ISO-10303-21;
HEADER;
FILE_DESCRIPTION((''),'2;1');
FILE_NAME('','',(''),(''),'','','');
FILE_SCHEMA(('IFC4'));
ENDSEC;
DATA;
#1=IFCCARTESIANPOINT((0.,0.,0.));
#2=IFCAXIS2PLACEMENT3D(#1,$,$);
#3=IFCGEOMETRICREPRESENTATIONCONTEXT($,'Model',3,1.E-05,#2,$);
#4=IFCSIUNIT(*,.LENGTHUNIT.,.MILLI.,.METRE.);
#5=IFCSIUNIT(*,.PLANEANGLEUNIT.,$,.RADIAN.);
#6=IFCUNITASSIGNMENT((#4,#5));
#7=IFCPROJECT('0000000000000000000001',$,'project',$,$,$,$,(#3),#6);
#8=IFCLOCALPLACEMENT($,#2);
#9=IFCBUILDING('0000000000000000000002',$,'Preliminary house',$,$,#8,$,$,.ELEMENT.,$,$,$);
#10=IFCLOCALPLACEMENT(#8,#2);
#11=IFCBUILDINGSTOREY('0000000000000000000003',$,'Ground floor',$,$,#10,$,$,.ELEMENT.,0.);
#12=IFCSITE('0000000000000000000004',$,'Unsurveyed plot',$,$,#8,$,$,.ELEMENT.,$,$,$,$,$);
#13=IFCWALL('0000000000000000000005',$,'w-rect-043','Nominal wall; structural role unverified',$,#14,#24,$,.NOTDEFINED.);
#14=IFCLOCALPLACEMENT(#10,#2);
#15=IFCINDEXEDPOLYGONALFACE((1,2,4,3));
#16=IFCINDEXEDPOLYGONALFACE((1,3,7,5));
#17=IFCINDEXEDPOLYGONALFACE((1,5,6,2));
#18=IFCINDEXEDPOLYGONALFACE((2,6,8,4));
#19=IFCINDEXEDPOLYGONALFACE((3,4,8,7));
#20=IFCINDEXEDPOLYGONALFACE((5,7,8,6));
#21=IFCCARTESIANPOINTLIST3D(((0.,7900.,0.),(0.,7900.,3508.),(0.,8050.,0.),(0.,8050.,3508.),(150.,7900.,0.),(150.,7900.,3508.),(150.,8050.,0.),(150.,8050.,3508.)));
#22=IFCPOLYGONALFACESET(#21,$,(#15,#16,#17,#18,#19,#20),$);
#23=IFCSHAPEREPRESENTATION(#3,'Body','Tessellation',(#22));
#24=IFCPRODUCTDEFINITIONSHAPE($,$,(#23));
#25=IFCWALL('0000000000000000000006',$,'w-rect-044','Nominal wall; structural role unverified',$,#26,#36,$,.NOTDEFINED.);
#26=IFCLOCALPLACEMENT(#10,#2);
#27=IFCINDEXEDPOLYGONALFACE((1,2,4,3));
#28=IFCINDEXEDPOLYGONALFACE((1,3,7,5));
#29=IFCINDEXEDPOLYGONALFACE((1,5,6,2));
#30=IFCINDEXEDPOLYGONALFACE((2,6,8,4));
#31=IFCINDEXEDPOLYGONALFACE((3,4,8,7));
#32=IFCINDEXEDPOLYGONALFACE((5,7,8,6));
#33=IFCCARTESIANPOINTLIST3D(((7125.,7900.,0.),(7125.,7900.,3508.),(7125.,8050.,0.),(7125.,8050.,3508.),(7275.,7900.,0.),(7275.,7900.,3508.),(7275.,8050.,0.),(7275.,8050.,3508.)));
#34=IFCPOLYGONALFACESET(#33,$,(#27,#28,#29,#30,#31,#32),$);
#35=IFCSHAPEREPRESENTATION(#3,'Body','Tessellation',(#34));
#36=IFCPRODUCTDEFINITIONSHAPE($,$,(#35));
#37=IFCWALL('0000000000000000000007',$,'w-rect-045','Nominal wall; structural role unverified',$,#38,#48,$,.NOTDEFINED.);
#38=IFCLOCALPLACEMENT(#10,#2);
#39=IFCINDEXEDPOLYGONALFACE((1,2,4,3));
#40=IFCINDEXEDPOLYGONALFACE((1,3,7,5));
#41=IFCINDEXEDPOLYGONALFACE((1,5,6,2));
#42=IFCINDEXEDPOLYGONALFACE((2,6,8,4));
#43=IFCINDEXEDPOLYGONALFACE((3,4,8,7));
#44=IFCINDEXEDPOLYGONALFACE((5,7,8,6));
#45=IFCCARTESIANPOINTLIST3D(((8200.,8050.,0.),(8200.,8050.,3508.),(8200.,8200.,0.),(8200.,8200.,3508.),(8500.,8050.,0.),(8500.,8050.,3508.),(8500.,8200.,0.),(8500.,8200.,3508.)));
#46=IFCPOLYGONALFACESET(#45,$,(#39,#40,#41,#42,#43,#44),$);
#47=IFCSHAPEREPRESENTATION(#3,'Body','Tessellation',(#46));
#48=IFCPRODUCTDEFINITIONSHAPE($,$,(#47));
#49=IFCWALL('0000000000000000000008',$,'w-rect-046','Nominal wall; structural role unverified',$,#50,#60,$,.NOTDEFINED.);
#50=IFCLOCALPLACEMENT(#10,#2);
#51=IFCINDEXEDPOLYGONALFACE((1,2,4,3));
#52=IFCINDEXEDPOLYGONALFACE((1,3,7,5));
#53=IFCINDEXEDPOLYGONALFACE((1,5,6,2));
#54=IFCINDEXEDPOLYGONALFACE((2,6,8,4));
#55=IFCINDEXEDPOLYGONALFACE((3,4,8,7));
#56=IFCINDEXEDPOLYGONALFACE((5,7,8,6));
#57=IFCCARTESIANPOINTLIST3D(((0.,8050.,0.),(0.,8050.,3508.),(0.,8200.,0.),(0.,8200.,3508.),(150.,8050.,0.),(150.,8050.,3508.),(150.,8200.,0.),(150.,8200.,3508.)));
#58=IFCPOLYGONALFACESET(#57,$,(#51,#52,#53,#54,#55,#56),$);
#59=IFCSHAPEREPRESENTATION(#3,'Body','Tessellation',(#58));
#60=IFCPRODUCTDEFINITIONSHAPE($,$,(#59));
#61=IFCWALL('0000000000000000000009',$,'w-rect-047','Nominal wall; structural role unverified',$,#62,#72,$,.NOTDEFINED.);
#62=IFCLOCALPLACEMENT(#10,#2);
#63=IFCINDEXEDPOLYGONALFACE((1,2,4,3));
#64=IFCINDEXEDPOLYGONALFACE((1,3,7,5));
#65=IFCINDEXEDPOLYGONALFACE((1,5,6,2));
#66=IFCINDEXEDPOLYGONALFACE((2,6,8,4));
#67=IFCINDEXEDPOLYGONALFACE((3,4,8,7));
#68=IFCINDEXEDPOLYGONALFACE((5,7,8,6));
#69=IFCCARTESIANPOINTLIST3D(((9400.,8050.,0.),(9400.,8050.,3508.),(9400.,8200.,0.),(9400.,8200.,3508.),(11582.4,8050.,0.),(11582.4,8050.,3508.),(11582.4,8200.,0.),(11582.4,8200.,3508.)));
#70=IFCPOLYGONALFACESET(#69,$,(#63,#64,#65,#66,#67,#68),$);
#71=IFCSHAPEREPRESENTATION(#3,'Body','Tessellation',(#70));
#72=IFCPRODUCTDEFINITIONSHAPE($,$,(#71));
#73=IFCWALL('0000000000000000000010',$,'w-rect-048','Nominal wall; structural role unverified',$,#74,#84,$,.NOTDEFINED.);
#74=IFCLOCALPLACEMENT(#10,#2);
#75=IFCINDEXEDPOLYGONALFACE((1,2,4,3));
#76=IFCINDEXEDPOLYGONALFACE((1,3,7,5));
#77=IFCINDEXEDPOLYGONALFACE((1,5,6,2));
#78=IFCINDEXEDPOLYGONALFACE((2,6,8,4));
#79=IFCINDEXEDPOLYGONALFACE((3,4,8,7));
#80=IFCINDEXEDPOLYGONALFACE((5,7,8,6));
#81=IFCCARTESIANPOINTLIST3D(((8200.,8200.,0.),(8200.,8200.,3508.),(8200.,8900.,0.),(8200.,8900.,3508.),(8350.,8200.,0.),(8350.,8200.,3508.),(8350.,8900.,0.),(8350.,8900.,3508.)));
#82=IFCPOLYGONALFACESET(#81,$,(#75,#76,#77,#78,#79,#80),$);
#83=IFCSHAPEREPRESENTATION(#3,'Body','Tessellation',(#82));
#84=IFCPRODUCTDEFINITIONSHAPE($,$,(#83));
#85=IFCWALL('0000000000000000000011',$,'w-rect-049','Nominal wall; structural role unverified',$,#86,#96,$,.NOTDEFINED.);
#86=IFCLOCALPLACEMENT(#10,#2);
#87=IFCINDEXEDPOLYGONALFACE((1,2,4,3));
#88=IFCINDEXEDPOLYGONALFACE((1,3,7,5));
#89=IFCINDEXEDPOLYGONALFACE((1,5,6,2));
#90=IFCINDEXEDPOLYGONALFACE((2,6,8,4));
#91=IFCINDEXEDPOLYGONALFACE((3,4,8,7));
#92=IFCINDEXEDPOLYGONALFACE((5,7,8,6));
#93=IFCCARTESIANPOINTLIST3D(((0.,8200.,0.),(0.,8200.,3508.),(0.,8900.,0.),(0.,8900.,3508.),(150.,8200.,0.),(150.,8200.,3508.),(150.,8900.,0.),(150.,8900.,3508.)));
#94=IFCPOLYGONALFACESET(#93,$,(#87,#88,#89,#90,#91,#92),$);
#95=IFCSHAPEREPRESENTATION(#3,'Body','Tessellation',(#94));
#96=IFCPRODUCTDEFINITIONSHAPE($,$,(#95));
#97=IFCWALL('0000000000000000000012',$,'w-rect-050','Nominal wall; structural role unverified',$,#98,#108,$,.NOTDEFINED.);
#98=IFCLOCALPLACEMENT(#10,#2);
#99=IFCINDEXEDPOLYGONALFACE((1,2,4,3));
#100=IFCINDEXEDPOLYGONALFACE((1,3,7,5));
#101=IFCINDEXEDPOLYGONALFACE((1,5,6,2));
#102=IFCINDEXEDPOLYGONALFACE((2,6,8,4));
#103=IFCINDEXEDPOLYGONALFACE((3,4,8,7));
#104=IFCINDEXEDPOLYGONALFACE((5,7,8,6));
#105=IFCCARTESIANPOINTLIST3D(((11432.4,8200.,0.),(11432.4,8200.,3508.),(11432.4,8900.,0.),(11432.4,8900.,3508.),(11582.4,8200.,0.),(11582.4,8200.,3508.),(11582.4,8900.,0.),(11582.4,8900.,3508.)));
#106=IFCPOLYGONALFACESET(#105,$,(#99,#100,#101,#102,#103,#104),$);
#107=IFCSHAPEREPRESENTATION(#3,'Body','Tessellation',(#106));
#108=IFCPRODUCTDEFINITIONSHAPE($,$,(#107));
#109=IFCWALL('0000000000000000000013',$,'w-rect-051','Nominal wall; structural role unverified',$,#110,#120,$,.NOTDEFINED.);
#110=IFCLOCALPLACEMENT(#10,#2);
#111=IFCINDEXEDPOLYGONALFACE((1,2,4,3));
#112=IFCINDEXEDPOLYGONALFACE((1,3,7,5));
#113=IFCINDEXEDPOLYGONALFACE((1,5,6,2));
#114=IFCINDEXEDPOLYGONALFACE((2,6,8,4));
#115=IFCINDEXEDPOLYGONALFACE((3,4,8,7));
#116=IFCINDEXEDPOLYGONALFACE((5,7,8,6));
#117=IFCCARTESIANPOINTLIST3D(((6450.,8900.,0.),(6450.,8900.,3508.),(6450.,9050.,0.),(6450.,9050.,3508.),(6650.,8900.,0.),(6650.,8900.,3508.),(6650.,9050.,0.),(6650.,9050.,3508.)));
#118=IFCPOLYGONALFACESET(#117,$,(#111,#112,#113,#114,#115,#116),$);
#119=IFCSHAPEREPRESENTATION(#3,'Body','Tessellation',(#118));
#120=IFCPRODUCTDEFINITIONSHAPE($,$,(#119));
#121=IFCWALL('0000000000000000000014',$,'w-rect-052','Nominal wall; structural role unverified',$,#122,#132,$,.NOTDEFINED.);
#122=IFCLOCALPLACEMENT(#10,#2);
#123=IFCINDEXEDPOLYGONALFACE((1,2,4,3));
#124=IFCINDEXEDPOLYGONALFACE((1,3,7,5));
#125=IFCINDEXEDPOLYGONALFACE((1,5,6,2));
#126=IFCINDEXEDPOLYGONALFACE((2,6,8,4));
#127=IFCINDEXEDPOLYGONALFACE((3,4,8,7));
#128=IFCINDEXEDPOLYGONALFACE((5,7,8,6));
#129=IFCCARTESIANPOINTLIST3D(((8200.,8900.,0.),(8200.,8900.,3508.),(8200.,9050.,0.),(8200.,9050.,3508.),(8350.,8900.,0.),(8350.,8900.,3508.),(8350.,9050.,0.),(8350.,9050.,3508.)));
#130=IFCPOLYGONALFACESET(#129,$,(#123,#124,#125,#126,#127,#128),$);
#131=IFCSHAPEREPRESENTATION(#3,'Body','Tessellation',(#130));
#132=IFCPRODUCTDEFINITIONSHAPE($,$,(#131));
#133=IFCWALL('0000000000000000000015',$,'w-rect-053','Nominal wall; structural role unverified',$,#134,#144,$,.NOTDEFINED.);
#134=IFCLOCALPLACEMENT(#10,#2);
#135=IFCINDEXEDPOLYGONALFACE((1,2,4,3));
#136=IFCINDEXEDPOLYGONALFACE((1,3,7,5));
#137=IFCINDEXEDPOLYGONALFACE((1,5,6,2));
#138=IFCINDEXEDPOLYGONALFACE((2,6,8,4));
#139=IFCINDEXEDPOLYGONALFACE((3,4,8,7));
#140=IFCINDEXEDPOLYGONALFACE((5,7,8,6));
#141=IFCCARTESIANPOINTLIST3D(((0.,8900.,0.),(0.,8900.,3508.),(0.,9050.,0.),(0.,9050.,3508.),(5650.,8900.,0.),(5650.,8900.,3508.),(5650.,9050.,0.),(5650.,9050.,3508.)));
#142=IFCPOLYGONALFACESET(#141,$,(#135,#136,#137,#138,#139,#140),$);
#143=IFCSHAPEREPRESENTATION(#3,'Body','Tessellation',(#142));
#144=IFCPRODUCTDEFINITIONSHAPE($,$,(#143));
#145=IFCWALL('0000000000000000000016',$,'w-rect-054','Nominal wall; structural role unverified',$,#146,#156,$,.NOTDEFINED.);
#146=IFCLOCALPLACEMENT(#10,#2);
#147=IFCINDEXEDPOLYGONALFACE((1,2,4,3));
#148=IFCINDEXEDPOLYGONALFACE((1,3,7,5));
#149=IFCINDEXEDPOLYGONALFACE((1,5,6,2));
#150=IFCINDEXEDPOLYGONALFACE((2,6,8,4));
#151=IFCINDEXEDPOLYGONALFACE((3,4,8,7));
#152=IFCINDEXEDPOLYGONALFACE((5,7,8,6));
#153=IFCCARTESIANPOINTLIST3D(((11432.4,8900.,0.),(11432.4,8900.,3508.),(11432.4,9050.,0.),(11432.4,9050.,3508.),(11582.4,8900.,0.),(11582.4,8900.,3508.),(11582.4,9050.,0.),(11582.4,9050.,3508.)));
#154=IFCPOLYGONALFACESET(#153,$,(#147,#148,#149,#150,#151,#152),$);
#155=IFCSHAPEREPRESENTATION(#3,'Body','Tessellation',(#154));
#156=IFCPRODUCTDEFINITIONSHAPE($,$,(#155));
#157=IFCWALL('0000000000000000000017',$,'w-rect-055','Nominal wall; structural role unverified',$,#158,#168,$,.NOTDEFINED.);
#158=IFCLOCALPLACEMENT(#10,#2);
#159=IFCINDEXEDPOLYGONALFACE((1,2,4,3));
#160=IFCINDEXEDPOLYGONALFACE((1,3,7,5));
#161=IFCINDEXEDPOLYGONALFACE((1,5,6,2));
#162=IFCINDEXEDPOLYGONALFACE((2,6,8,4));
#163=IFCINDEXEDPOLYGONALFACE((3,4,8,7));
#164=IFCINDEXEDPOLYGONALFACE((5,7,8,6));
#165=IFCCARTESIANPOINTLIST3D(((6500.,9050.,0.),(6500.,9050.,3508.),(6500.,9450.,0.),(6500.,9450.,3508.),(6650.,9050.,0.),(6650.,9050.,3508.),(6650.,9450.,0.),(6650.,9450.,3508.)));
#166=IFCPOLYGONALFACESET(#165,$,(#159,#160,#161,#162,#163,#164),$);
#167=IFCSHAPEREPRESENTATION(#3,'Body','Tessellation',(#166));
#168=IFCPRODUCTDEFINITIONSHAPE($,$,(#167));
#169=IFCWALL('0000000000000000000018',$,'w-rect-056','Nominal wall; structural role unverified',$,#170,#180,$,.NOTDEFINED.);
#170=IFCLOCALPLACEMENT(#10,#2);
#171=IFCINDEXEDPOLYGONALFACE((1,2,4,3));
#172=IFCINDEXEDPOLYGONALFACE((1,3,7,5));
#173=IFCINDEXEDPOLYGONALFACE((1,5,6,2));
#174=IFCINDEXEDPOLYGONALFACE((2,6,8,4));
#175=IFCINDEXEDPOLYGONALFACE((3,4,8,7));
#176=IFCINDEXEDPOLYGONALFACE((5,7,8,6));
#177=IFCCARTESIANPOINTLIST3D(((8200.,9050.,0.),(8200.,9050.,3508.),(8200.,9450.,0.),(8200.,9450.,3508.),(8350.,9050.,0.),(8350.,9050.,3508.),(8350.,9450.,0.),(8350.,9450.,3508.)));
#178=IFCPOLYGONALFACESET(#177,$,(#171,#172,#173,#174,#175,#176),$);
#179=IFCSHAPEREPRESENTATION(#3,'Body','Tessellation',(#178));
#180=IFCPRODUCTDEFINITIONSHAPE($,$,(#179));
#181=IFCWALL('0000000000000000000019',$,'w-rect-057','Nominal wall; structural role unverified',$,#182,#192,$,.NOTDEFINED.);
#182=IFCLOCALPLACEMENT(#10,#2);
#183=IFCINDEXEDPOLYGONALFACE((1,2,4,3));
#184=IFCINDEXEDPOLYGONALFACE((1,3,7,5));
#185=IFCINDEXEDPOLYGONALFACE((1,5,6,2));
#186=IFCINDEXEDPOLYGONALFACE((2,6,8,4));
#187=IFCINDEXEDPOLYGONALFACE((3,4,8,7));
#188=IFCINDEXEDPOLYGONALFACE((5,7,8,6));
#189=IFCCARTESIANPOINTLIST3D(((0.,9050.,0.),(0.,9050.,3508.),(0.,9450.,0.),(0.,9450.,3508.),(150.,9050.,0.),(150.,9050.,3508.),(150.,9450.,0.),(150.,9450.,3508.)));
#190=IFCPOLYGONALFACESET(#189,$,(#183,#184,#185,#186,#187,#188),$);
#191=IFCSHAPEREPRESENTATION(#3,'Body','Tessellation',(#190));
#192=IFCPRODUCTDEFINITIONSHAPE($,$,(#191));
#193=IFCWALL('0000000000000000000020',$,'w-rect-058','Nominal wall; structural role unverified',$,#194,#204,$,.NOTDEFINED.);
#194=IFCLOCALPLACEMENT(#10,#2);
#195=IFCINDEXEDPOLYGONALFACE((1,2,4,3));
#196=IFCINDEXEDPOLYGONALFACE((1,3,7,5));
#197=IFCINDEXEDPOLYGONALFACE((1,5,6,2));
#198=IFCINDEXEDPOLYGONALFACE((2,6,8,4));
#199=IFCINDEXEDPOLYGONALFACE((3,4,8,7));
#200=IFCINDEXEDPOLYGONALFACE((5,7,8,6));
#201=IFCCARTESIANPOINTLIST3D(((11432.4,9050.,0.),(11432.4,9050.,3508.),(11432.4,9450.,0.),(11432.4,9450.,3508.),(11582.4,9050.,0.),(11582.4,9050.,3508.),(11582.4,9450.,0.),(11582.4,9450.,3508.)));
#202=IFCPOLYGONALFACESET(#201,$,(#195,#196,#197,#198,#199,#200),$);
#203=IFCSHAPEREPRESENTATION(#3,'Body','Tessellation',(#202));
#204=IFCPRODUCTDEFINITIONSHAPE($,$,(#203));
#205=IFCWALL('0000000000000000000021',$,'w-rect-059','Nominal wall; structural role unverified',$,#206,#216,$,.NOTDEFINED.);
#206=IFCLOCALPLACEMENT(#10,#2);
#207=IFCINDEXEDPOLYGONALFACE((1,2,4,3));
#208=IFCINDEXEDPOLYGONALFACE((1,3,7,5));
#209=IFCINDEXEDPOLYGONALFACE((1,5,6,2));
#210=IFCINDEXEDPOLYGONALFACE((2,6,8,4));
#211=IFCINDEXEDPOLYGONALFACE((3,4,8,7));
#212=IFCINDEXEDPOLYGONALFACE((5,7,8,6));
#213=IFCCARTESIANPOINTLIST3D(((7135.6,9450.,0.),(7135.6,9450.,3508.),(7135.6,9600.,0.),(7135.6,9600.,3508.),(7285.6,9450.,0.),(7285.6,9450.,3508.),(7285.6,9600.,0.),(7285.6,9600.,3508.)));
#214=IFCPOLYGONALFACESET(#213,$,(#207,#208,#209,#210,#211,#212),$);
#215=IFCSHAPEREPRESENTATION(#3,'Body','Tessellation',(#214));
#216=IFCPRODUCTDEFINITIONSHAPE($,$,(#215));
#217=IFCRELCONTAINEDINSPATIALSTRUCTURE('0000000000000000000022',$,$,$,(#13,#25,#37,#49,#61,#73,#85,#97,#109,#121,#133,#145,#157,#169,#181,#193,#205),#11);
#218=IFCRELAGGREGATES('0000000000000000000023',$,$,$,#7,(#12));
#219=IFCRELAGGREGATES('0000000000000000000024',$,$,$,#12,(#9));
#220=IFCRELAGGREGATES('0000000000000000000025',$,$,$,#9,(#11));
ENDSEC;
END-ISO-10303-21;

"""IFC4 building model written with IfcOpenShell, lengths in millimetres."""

from ifc_helpers import new_model, si_unit, origin, place, context, project, spatial, polyline, outline, extrude, element, save


model = new_model("IFC4")

# Units and contexts
model_context = context("Model", 3, precision=1e-05, world=origin())
ifc_project = project(units=[si_unit("LENGTHUNIT", "METRE", prefix="MILLI"), si_unit("PLANEANGLEUNIT", "RADIAN")], contexts=[model_context])

# Site, building, storey
placement_1 = place(None, origin())
site = spatial("IfcSite", under=ifc_project, at=placement_1, Name="Unsurveyed plot", CompositionType="ELEMENT")
building = spatial("IfcBuilding", under=site, at=placement_1, Name="Preliminary house", CompositionType="ELEMENT")
placement_2 = place(placement_1, origin())
storey = spatial("IfcBuildingStorey", under=building, at=placement_2, Name="Ground floor", CompositionType="ELEMENT", Elevation=0.0)

# Walls
element("IfcWall", 1, at=placement_2, inside=storey, Name="w-rect-043", Description="Nominal wall; structural role unverified", PredefinedType="NOTDEFINED", context=model_context, shape_type="SweptSolid", body=[
    extrude(outline(polyline([(0.0, 7900.0), (150.0, 7900.0), (150.0, 8050.0), (0.0, 8050.0), (0.0, 7900.0)])), origin(), (0.0, 0.0, 1.0), 3508.0),
])
element("IfcWall", 2, at=placement_2, inside=storey, Name="w-rect-044", Description="Nominal wall; structural role unverified", PredefinedType="NOTDEFINED", context=model_context, shape_type="SweptSolid", body=[
    extrude(outline(polyline([(7125.0, 7900.0), (7275.0, 7900.0), (7275.0, 8050.0), (7125.0, 8050.0), (7125.0, 7900.0)])), origin(), (0.0, 0.0, 1.0), 3508.0),
])
element("IfcWall", 3, at=placement_2, inside=storey, Name="w-rect-045", Description="Nominal wall; structural role unverified", PredefinedType="NOTDEFINED", context=model_context, shape_type="SweptSolid", body=[
    extrude(outline(polyline([(8200.0, 8050.0), (8500.0, 8050.0), (8500.0, 8200.0), (8200.0, 8200.0), (8200.0, 8050.0)])), origin(), (0.0, 0.0, 1.0), 3508.0),
])
element("IfcWall", 4, at=placement_2, inside=storey, Name="w-rect-046", Description="Nominal wall; structural role unverified", PredefinedType="NOTDEFINED", context=model_context, shape_type="SweptSolid", body=[
    extrude(outline(polyline([(0.0, 8050.0), (150.0, 8050.0), (150.0, 8200.0), (0.0, 8200.0), (0.0, 8050.0)])), origin(), (0.0, 0.0, 1.0), 3508.0),
])
element("IfcWall", 5, at=placement_2, inside=storey, Name="w-rect-047", Description="Nominal wall; structural role unverified", PredefinedType="NOTDEFINED", context=model_context, shape_type="SweptSolid", body=[
    extrude(outline(polyline([(9400.0, 8050.0), (11582.4, 8050.0), (11582.4, 8200.0), (9400.0, 8200.0), (9400.0, 8050.0)])), origin(), (0.0, 0.0, 1.0), 3508.0),
])
element("IfcWall", 6, at=placement_2, inside=storey, Name="w-rect-048", Description="Nominal wall; structural role unverified", PredefinedType="NOTDEFINED", context=model_context, shape_type="SweptSolid", body=[
    extrude(outline(polyline([(8200.0, 8200.0), (8350.0, 8200.0), (8350.0, 8900.0), (8200.0, 8900.0), (8200.0, 8200.0)])), origin(), (0.0, 0.0, 1.0), 3508.0),
])
element("IfcWall", 7, at=placement_2, inside=storey, Name="w-rect-049", Description="Nominal wall; structural role unverified", PredefinedType="NOTDEFINED", context=model_context, shape_type="SweptSolid", body=[
    extrude(outline(polyline([(0.0, 8200.0), (150.0, 8200.0), (150.0, 8900.0), (0.0, 8900.0), (0.0, 8200.0)])), origin(), (0.0, 0.0, 1.0), 3508.0),
])
element("IfcWall", 8, at=placement_2, inside=storey, Name="w-rect-050", Description="Nominal wall; structural role unverified", PredefinedType="NOTDEFINED", context=model_context, shape_type="SweptSolid", body=[
    extrude(outline(polyline([(11432.4, 8200.0), (11582.4, 8200.0), (11582.4, 8900.0), (11432.4, 8900.0), (11432.4, 8200.0)])), origin(), (0.0, 0.0, 1.0), 3508.0),
])
element("IfcWall", 9, at=placement_2, inside=storey, Name="w-rect-051", Description="Nominal wall; structural role unverified", PredefinedType="NOTDEFINED", context=model_context, shape_type="SweptSolid", body=[
    extrude(outline(polyline([(6450.0, 8900.0), (6650.0, 8900.0), (6650.0, 9050.0), (6450.0, 9050.0), (6450.0, 8900.0)])), origin(), (0.0, 0.0, 1.0), 3508.0),
])
element("IfcWall", 10, at=placement_2, inside=storey, Name="w-rect-052", Description="Nominal wall; structural role unverified", PredefinedType="NOTDEFINED", context=model_context, shape_type="SweptSolid", body=[
    extrude(outline(polyline([(8200.0, 8900.0), (8350.0, 8900.0), (8350.0, 9050.0), (8200.0, 9050.0), (8200.0, 8900.0)])), origin(), (0.0, 0.0, 1.0), 3508.0),
])
element("IfcWall", 11, at=placement_2, inside=storey, Name="w-rect-053", Description="Nominal wall; structural role unverified", PredefinedType="NOTDEFINED", context=model_context, shape_type="SweptSolid", body=[
    extrude(outline(polyline([(0.0, 8900.0), (5650.0, 8900.0), (5650.0, 9050.0), (0.0, 9050.0), (0.0, 8900.0)])), origin(), (0.0, 0.0, 1.0), 3508.0),
])
element("IfcWall", 12, at=placement_2, inside=storey, Name="w-rect-054", Description="Nominal wall; structural role unverified", PredefinedType="NOTDEFINED", context=model_context, shape_type="SweptSolid", body=[
    extrude(outline(polyline([(11432.4, 8900.0), (11582.4, 8900.0), (11582.4, 9050.0), (11432.4, 9050.0), (11432.4, 8900.0)])), origin(), (0.0, 0.0, 1.0), 3508.0),
])
element("IfcWall", 13, at=placement_2, inside=storey, Name="w-rect-055", Description="Nominal wall; structural role unverified", PredefinedType="NOTDEFINED", context=model_context, shape_type="SweptSolid", body=[
    extrude(outline(polyline([(6500.0, 9050.0), (6650.0, 9050.0), (6650.0, 9450.0), (6500.0, 9450.0), (6500.0, 9050.0)])), origin(), (0.0, 0.0, 1.0), 3508.0),
])
element("IfcWall", 14, at=placement_2, inside=storey, Name="w-rect-056", Description="Nominal wall; structural role unverified", PredefinedType="NOTDEFINED", context=model_context, shape_type="SweptSolid", body=[
    extrude(outline(polyline([(8200.0, 9050.0), (8350.0, 9050.0), (8350.0, 9450.0), (8200.0, 9450.0), (8200.0, 9050.0)])), origin(), (0.0, 0.0, 1.0), 3508.0),
])
element("IfcWall", 15, at=placement_2, inside=storey, Name="w-rect-057", Description="Nominal wall; structural role unverified", PredefinedType="NOTDEFINED", context=model_context, shape_type="SweptSolid", body=[
    extrude(outline(polyline([(0.0, 9050.0), (150.0, 9050.0), (150.0, 9450.0), (0.0, 9450.0), (0.0, 9050.0)])), origin(), (0.0, 0.0, 1.0), 3508.0),
])
element("IfcWall", 16, at=placement_2, inside=storey, Name="w-rect-058", Description="Nominal wall; structural role unverified", PredefinedType="NOTDEFINED", context=model_context, shape_type="SweptSolid", body=[
    extrude(outline(polyline([(11432.4, 9050.0), (11582.4, 9050.0), (11582.4, 9450.0), (11432.4, 9450.0), (11432.4, 9050.0)])), origin(), (0.0, 0.0, 1.0), 3508.0),
])
element("IfcWall", 17, at=placement_2, inside=storey, Name="w-rect-059", Description="Nominal wall; structural role unverified", PredefinedType="NOTDEFINED", context=model_context, shape_type="SweptSolid", body=[
    extrude(outline(polyline([(7135.6, 9450.0), (7285.6, 9450.0), (7285.6, 9600.0), (7135.6, 9600.0), (7135.6, 9450.0)])), origin(), (0.0, 0.0, 1.0), 3508.0),
])

save(model, "model.ifc")
